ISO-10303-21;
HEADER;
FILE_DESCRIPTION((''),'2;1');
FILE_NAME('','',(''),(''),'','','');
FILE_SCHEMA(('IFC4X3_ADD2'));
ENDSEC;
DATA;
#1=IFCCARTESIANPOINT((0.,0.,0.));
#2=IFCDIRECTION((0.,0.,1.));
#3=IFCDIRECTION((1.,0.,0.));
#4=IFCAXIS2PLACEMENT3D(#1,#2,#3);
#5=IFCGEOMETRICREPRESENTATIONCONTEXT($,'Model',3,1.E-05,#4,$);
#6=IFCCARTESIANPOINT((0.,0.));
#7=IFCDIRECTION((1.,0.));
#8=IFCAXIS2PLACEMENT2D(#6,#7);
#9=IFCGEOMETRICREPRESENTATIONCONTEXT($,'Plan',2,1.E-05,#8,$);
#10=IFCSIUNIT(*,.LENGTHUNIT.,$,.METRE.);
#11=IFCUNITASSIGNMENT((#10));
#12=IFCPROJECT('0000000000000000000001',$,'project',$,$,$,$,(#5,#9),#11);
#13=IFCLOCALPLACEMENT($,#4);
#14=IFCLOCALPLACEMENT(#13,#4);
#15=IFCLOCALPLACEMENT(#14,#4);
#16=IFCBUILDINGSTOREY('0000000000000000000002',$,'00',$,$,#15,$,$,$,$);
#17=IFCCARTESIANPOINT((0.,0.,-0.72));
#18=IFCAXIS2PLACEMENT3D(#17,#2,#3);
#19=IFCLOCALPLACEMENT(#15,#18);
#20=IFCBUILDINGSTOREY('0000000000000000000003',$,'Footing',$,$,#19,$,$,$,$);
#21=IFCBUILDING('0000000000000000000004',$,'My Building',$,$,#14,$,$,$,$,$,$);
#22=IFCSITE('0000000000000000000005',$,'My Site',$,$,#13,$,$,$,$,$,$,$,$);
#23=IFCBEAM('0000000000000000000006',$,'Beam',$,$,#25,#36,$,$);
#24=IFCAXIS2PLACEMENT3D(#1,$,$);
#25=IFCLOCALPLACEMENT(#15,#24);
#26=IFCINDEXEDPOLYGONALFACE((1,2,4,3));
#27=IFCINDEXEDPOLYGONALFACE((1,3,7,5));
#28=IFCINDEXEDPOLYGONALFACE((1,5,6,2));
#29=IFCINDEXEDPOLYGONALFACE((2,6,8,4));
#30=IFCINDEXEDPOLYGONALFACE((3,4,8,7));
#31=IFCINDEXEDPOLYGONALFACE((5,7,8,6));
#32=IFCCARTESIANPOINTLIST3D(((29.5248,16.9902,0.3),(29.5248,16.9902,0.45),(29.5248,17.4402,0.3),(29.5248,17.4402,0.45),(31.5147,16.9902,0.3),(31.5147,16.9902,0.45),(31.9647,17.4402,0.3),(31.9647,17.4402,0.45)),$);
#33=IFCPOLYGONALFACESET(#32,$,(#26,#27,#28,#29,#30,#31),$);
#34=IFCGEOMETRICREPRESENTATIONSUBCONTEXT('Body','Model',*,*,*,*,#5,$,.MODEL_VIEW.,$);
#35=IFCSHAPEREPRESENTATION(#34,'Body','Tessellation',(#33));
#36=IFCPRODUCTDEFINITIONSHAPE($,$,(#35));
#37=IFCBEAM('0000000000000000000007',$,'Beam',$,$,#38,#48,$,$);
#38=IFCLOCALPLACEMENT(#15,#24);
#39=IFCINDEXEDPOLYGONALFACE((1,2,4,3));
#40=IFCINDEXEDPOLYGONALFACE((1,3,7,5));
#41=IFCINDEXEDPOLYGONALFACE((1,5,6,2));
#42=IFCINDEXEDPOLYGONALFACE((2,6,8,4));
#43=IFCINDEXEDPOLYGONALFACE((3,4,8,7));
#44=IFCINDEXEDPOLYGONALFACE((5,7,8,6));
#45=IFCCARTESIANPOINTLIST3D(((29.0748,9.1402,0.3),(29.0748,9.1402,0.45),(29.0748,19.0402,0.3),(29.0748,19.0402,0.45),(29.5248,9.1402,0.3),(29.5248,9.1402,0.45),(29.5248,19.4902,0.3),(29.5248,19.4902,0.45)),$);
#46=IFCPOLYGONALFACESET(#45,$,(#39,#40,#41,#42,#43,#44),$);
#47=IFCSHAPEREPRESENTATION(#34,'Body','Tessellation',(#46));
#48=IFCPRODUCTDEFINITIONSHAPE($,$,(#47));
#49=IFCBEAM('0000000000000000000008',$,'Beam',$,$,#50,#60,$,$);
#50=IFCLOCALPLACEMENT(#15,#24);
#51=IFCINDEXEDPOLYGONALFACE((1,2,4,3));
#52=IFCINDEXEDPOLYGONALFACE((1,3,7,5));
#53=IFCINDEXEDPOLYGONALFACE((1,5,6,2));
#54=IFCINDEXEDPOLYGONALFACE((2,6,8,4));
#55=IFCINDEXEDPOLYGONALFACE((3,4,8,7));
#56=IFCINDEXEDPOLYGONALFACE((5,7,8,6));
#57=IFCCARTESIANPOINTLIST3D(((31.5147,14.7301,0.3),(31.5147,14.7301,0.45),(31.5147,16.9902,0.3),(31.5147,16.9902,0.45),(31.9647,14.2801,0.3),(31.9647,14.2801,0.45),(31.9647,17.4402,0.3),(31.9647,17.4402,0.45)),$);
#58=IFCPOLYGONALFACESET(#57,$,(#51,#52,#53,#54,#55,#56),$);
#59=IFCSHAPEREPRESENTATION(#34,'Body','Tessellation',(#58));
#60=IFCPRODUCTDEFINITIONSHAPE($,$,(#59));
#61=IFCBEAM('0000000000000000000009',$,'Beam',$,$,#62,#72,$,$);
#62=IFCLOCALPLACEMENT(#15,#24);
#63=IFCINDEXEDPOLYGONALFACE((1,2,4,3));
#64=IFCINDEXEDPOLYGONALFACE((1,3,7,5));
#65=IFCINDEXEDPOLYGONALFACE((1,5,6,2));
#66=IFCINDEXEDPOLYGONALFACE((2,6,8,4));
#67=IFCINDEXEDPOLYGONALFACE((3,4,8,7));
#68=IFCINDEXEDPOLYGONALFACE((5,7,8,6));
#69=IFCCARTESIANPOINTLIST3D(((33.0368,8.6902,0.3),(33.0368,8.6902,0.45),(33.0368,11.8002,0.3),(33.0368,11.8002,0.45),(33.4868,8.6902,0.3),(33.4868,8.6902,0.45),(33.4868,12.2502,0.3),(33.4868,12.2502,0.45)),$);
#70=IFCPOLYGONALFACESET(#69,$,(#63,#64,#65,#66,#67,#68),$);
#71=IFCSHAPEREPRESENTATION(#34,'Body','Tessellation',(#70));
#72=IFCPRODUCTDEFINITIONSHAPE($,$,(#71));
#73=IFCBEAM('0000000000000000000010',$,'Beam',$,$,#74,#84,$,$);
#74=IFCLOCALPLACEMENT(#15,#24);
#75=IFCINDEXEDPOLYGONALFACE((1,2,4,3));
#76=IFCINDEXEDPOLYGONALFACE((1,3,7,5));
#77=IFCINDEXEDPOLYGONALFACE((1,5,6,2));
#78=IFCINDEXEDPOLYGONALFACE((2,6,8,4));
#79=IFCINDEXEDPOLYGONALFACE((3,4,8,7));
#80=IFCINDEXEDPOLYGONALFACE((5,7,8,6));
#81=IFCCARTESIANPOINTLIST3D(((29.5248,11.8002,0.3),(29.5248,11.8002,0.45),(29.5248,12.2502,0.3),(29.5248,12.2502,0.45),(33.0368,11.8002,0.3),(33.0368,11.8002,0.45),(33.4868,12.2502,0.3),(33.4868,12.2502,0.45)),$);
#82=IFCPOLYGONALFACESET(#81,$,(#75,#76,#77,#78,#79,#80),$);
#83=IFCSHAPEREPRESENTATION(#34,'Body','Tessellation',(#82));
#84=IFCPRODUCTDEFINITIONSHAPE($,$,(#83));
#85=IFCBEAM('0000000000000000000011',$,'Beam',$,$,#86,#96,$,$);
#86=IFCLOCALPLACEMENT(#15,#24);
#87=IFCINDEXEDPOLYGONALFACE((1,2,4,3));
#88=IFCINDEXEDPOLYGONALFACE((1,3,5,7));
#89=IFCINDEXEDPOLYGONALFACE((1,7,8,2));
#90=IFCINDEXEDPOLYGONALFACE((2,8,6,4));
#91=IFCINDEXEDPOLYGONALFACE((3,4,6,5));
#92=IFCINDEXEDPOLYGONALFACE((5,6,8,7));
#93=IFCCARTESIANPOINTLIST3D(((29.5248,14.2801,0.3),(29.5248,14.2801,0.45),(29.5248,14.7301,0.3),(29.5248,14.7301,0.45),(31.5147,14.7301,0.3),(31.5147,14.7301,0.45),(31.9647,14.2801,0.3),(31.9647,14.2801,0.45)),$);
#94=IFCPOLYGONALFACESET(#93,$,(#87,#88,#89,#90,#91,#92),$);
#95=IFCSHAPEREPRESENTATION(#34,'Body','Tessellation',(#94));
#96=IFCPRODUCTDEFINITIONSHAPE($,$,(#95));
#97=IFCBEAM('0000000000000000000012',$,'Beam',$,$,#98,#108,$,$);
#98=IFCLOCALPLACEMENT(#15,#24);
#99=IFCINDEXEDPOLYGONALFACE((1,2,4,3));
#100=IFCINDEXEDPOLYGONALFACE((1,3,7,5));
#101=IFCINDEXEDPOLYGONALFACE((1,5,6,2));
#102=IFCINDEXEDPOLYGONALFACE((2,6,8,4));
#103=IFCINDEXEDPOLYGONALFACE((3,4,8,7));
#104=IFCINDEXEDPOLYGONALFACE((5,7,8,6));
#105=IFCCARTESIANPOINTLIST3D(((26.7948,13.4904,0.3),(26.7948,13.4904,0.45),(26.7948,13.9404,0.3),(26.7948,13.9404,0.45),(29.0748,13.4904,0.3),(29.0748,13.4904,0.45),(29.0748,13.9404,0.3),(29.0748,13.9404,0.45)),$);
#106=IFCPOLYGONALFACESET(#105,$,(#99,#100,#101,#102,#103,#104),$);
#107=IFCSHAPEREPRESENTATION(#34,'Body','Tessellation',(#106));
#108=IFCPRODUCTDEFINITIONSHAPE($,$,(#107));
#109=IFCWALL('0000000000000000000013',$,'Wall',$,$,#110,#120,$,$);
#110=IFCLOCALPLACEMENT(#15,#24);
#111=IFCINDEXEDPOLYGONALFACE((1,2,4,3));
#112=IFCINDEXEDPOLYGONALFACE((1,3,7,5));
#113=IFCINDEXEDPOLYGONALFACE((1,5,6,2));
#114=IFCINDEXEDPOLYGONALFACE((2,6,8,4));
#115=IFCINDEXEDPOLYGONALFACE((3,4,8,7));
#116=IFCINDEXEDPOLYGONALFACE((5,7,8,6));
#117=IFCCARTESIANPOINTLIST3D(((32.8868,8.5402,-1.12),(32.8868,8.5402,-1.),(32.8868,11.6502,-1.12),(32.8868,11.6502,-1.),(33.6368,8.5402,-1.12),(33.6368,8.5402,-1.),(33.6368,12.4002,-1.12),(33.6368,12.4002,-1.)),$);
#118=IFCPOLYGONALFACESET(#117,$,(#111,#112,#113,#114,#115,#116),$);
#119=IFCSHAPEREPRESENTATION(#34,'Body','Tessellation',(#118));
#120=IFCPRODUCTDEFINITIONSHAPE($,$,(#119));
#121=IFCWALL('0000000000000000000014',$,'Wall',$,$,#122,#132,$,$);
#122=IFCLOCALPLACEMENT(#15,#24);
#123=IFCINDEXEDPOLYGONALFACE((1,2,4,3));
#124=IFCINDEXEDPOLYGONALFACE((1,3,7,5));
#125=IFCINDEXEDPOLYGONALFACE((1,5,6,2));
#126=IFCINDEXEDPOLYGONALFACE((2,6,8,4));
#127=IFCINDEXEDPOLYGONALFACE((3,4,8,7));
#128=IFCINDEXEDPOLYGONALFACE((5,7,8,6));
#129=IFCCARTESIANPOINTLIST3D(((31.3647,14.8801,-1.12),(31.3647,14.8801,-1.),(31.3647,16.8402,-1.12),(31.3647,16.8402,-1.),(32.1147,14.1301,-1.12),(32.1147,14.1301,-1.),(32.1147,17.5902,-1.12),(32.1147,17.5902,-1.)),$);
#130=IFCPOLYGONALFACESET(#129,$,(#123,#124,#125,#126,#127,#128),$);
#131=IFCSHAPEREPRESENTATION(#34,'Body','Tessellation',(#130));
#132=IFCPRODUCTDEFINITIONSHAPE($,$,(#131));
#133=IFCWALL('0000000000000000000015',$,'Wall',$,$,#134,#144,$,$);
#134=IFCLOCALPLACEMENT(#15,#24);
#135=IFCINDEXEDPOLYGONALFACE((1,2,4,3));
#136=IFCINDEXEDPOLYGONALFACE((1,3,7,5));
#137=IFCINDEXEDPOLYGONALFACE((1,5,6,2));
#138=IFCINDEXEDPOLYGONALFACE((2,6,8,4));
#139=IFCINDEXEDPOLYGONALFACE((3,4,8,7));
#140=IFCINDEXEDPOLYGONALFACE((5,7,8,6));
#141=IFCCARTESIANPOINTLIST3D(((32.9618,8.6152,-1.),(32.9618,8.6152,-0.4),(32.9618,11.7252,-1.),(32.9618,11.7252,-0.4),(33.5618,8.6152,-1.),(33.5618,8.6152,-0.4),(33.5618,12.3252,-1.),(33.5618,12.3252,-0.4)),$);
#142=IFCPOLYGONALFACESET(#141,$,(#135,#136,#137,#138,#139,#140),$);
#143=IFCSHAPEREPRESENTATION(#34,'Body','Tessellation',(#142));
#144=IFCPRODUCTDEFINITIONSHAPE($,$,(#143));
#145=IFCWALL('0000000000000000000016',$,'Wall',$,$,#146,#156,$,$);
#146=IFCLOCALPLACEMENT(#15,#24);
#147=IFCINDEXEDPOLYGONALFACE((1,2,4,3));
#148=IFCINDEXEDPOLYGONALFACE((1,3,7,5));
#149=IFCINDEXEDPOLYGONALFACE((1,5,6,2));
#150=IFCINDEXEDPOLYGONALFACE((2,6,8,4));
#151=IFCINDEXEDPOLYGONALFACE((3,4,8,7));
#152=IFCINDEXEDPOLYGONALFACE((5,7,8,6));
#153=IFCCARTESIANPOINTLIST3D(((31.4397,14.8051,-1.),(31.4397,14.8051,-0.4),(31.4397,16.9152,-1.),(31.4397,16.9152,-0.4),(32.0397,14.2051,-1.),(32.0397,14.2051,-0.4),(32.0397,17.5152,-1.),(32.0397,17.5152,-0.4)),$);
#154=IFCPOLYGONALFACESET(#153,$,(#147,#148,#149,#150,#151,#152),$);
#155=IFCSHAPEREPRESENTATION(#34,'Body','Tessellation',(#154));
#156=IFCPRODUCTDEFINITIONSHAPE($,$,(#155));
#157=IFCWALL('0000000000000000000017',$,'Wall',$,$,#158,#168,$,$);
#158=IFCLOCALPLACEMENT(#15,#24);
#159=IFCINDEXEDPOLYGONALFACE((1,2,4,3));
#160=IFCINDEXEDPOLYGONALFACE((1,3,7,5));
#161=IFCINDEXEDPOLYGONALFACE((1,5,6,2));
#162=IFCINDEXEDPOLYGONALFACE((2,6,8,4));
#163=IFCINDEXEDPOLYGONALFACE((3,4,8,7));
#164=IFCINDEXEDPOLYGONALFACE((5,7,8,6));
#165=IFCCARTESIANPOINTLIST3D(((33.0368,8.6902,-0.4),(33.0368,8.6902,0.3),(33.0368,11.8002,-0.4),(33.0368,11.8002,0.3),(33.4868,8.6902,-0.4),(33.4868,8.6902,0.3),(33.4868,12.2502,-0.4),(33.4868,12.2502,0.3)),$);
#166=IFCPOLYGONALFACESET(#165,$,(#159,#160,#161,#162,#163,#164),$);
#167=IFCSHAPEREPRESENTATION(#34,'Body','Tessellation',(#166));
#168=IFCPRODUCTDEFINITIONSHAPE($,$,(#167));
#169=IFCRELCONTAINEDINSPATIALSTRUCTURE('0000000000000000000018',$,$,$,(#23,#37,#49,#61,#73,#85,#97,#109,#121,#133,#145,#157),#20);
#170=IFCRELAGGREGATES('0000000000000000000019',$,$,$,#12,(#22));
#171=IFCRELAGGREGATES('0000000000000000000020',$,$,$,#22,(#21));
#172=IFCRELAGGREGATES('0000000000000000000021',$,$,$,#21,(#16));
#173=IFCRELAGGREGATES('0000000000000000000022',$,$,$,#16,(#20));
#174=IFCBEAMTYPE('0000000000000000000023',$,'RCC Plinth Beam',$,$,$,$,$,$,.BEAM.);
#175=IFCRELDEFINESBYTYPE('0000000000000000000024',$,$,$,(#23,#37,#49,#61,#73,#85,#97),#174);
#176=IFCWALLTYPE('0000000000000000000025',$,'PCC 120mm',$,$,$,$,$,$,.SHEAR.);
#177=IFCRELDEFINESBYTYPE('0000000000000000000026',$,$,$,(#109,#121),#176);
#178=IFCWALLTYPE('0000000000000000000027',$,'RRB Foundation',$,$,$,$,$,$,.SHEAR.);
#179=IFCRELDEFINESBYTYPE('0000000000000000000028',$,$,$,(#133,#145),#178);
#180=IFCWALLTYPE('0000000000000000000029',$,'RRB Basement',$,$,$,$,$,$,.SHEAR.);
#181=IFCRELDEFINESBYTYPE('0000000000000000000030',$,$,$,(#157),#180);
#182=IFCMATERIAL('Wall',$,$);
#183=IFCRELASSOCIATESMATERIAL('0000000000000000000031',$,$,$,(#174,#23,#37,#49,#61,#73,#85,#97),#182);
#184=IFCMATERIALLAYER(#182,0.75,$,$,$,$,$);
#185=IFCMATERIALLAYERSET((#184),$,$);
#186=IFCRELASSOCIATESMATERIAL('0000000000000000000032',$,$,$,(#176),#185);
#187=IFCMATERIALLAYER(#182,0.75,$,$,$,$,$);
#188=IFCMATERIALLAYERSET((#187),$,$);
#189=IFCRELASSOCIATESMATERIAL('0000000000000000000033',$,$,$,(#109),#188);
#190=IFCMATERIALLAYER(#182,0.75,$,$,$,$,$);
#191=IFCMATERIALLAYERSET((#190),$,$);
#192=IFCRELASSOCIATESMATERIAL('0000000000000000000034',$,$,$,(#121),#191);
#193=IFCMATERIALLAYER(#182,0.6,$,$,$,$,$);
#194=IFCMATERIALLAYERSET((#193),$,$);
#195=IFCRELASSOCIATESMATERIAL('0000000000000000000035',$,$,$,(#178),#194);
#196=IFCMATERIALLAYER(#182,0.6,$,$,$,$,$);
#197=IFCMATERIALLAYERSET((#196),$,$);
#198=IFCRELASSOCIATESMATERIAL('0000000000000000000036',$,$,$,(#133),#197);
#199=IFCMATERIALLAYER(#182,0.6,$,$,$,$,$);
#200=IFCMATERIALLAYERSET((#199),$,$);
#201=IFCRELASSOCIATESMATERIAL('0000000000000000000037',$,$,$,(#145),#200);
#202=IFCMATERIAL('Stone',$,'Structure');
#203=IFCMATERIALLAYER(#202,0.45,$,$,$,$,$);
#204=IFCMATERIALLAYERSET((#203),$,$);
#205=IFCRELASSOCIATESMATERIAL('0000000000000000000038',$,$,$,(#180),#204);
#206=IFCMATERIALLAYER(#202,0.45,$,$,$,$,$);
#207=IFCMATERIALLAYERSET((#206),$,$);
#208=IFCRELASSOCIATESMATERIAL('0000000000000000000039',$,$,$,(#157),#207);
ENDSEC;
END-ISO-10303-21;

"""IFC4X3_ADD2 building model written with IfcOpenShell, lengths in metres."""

from ifc_helpers import new_model, si_unit, frame, origin_with_axes, origin_2d_with_axis, place, context, subcontext, project, spatial, line, indexed_curve, rectangle, outline, extrude, clip, halfspace, material, layer, layer_set, layer_usage, material_profile, profile_set, profile_usage, type_object, element, save


model = new_model("IFC4X3_ADD2")

# Units and contexts
model_context = context("Model", 3, precision=1e-05, world=origin_with_axes())
plan_context = context("Plan", 2, precision=1e-05, world=origin_2d_with_axis())
body_context = subcontext(model_context, "Body", "Model", "MODEL_VIEW")
ifc_project = project(units=[si_unit("LENGTHUNIT", "METRE")], contexts=[model_context, plan_context])

# Site, building, storeys
site_placement = place(None, origin_with_axes())
site = spatial("IfcSite", under=ifc_project, at=site_placement, Name="My Site")
building_placement = place(site_placement, origin_with_axes())
building = spatial("IfcBuilding", under=site, at=building_placement, Name="My Building")
storey_1_placement = place(building_placement, origin_with_axes())
storey_1 = spatial("IfcBuildingStorey", under=building, at=storey_1_placement, Name="00")
storey_2_placement = place(storey_1_placement, frame((0.0, 0.0, -0.72), z_axis=(0.0, 0.0, 1.0), x_axis=(1.0, 0.0, 0.0)))
storey_2 = spatial("IfcBuildingStorey", under=storey_1, at=storey_2_placement, Name="Footing")

# Beams
ifc_material_1 = material(Name="Wall")
ifc_material_profile_1 = material_profile(ifc_material_1, rectangle(XDim=0.45, YDim=0.15))
ifc_profile_set_1 = profile_set([ifc_material_profile_1])
ifc_profile_usage_1 = profile_usage(ifc_profile_set_1, cardinal=5)
beam_type = type_object("IfcBeamType", Name="RCC Plinth Beam", PredefinedType="BEAM", material=ifc_profile_set_1)
beam_1_placement = place(storey_2_placement, frame((29.5248, 17.2152, 1.095), z_axis=(1.0, 0.0, 0.0), x_axis=(0.0, 1.0, 0.0)))
element("IfcBeam", 1, at=beam_1_placement, inside=storey_2, type_object=beam_type, material=ifc_profile_usage_1, Name="Beam", context=body_context, shape_type="Clipping", body=[
    clip(extrude(rectangle(XDim=0.45, YDim=0.15), origin_with_axes(), (0.0, 0.0, 1.0), 2.44), halfspace(frame((0.225, -0.375, 2.44), z_axis=(-0.707107, 0.0, 0.707107), x_axis=(0.0, 1.0, 0.0)), False)),
])
ifc_material_profile_2 = material_profile(ifc_material_1, rectangle(XDim=0.45, YDim=0.15))
ifc_profile_set_2 = profile_set([ifc_material_profile_2])
ifc_profile_usage_2 = profile_usage(ifc_profile_set_2, cardinal=5)
beam_2_placement = place(storey_2_placement, frame((29.2998, 9.1402, 1.095), z_axis=(0.0, 1.0, 0.0), x_axis=(-1.0, 0.0, 0.0)))
element("IfcBeam", 2, at=beam_2_placement, inside=storey_2, type_object=beam_type, material=ifc_profile_usage_2, Name="Beam", context=body_context, shape_type="Clipping", body=[
    clip(extrude(rectangle(XDim=0.45, YDim=0.15), origin_with_axes(), (0.0, 0.0, 1.0), 10.35), halfspace(frame((-0.225, -0.375, 10.35), z_axis=(0.707107, 0.0, 0.707107), x_axis=(0.0, -1.0, 0.0)), False)),
])
ifc_material_profile_3 = material_profile(ifc_material_1, rectangle(XDim=0.45, YDim=0.15))
ifc_profile_set_3 = profile_set([ifc_material_profile_3])
ifc_profile_usage_3 = profile_usage(ifc_profile_set_3, cardinal=5)
beam_3_placement = place(storey_2_placement, frame((31.7397, 14.2801, 1.095), z_axis=(0.0, 1.0, 0.0), x_axis=(-1.0, 0.0, 0.0)))
element("IfcBeam", 3, at=beam_3_placement, inside=storey_2, type_object=beam_type, material=ifc_profile_usage_3, Name="Beam", context=body_context, shape_type="Clipping", body=[
    clip(clip(extrude(rectangle(XDim=0.45, YDim=0.15), origin_with_axes(), (0.0, 0.0, 1.0), 3.16), halfspace(frame((-0.225, -0.375, 3.16), z_axis=(0.707107, 0.0, 0.707107), x_axis=(0.0, -1.0, 0.0)), False)), halfspace(frame((-0.225, -0.375, 0.0), z_axis=(0.707107, 0.0, -0.707107), x_axis=(0.0, -1.0, 0.0)), False)),
])
ifc_material_profile_4 = material_profile(ifc_material_1, rectangle(XDim=0.45, YDim=0.15))
ifc_profile_set_4 = profile_set([ifc_material_profile_4])
ifc_profile_usage_4 = profile_usage(ifc_profile_set_4, cardinal=5)
beam_4_placement = place(storey_2_placement, frame((33.2618, 8.6902, 1.095), z_axis=(0.0, 1.0, 0.0), x_axis=(-1.0, 0.0, 0.0)))
element("IfcBeam", 4, at=beam_4_placement, inside=storey_2, type_object=beam_type, material=ifc_profile_usage_4, Name="Beam", context=body_context, shape_type="Clipping", body=[
    clip(extrude(rectangle(XDim=0.45, YDim=0.15), origin_with_axes(), (0.0, 0.0, 1.0), 3.56), halfspace(frame((-0.225, -0.375, 3.56), z_axis=(0.70711, 0.0, 0.707104), x_axis=(0.0, -1.0, 0.0)), False)),
])
ifc_profile_usage_5 = profile_usage(ifc_profile_set_1, cardinal=5)
beam_5_placement = place(storey_2_placement, frame((29.5248, 12.0252, 1.095), z_axis=(1.0, 0.0, 0.0), x_axis=(0.0, 1.0, 0.0)))
element("IfcBeam", 5, at=beam_5_placement, inside=storey_2, type_object=beam_type, material=ifc_profile_usage_5, Name="Beam", context=body_context, shape_type="Clipping", body=[
    clip(extrude(rectangle(XDim=0.45, YDim=0.15), origin_with_axes(), (0.0, 0.0, 1.0), 3.962), halfspace(frame((0.225, -0.375, 3.962), z_axis=(-0.707104, 0.0, 0.70711), x_axis=(0.0, 1.0, 0.0)), False)),
])
ifc_profile_usage_6 = profile_usage(ifc_profile_set_1, cardinal=5)
beam_6_placement = place(storey_2_placement, frame((29.5248, 14.5051, 1.095), z_axis=(1.0, 0.0, 0.0), x_axis=(0.0, 1.0, 0.0)))
element("IfcBeam", 6, at=beam_6_placement, inside=storey_2, type_object=beam_type, material=ifc_profile_usage_6, Name="Beam", context=body_context, shape_type="Clipping", body=[
    clip(extrude(rectangle(XDim=0.45, YDim=0.15), origin_with_axes(), (0.0, 0.0, 1.0), 2.44), halfspace(frame((-0.225, -0.375, 2.44), z_axis=(0.707107, 0.0, 0.707107), x_axis=(0.0, -1.0, 0.0)), False)),
])
ifc_profile_usage_7 = profile_usage(ifc_profile_set_1, cardinal=5)
beam_7_placement = place(storey_2_placement, frame((26.7948, 13.7154, 1.095), z_axis=(1.0, 0.0, 0.0), x_axis=(0.0, 1.0, 0.0)))
element("IfcBeam", 7, at=beam_7_placement, inside=storey_2, type_object=beam_type, material=ifc_profile_usage_7, Name="Beam", context=body_context, shape_type="SweptSolid", body=[
    extrude(rectangle(XDim=0.45, YDim=0.15), origin_with_axes(), (0.0, 0.0, 1.0), 2.28),
])

# Walls
ifc_layer_1 = layer(ifc_material_1, 0.75)
ifc_layer_set_1 = layer_set([ifc_layer_1])
wall_type_1 = type_object("IfcWallType", Name="PCC 120mm", PredefinedType="SHEAR", material=ifc_layer_set_1)
ifc_layer_2 = layer(ifc_material_1, 0.75)
ifc_layer_set_2 = layer_set([ifc_layer_2])
ifc_layer_usage_1 = layer_usage(ifc_layer_set_2, "AXIS2", "NEGATIVE", 0.0)
wall_1_placement = place(storey_2_placement, frame((32.8868, 8.5402, -0.4), z_axis=(0.0, 0.0, 1.0), x_axis=(0.0, 1.0, 0.0)))
element("IfcWall", 8, at=wall_1_placement, inside=storey_2, type_object=wall_type_1, material=ifc_layer_usage_1, Name="Wall", context=body_context, shape_type="SweptSolid", body=[
    extrude(outline(indexed_curve([(0.0, -0.75), (0.0, 0.0), (3.11, 0.0), (3.86, -0.75)], segments=[line(1, 2, 3, 4, 1)])), origin_with_axes(), (0.0, 0.0, 1.0), 0.12),
])
ifc_layer_3 = layer(ifc_material_1, 0.75)
ifc_layer_set_3 = layer_set([ifc_layer_3])
ifc_layer_usage_2 = layer_usage(ifc_layer_set_3, "AXIS2", "NEGATIVE", 0.0)
wall_2_placement = place(storey_2_placement, frame((31.3647, 14.1301, -0.4), z_axis=(0.0, 0.0, 1.0), x_axis=(0.0, 1.0, 0.0)))
element("IfcWall", 9, at=wall_2_placement, inside=storey_2, type_object=wall_type_1, material=ifc_layer_usage_2, Name="Wall", context=body_context, shape_type="SweptSolid", body=[
    extrude(outline(indexed_curve([(0.0, -0.75), (0.75, 0.0), (2.71, 0.0), (3.46, -0.75)], segments=[line(1, 2, 3, 4, 1)])), origin_with_axes(), (0.0, 0.0, 1.0), 0.12),
])
ifc_layer_4 = layer(ifc_material_1, 0.6)
ifc_layer_set_4 = layer_set([ifc_layer_4])
wall_type_2 = type_object("IfcWallType", Name="RRB Foundation", PredefinedType="SHEAR", material=ifc_layer_set_4)
ifc_layer_5 = layer(ifc_material_1, 0.6)
ifc_layer_set_5 = layer_set([ifc_layer_5])
ifc_layer_usage_3 = layer_usage(ifc_layer_set_5, "AXIS2", "NEGATIVE", 0.0)
wall_3_placement = place(storey_2_placement, frame((32.9618, 8.6152, -0.28), z_axis=(0.0, 0.0, 1.0), x_axis=(0.0, 1.0, 0.0)))
element("IfcWall", 10, at=wall_3_placement, inside=storey_2, type_object=wall_type_2, material=ifc_layer_usage_3, Name="Wall", context=body_context, shape_type="SweptSolid", body=[
    extrude(outline(indexed_curve([(0.0, -0.6), (0.0, 0.0), (3.11, 0.0), (3.71, -0.6)], segments=[line(1, 2, 3, 4, 1)])), origin_with_axes(), (0.0, 0.0, 1.0), 0.6),
])
ifc_layer_6 = layer(ifc_material_1, 0.6)
ifc_layer_set_6 = layer_set([ifc_layer_6])
ifc_layer_usage_4 = layer_usage(ifc_layer_set_6, "AXIS2", "NEGATIVE", 0.0)
wall_4_placement = place(storey_2_placement, frame((31.4397, 14.2051, -0.28), z_axis=(0.0, 0.0, 1.0), x_axis=(0.0, 1.0, 0.0)))
element("IfcWall", 11, at=wall_4_placement, inside=storey_2, type_object=wall_type_2, material=ifc_layer_usage_4, Name="Wall", context=body_context, shape_type="SweptSolid", body=[
    extrude(outline(indexed_curve([(0.0, -0.6), (0.6, 0.0), (2.71, 0.0), (3.31, -0.6)], segments=[line(1, 2, 3, 4, 1)])), origin_with_axes(), (0.0, 0.0, 1.0), 0.6),
])
ifc_material_2 = material(Name="Stone", Category="Structure")
ifc_layer_7 = layer(ifc_material_2, 0.45)
ifc_layer_set_7 = layer_set([ifc_layer_7])
wall_type_3 = type_object("IfcWallType", Name="RRB Basement", PredefinedType="SHEAR", material=ifc_layer_set_7)
ifc_layer_8 = layer(ifc_material_2, 0.45)
ifc_layer_set_8 = layer_set([ifc_layer_8])
ifc_layer_usage_5 = layer_usage(ifc_layer_set_8, "AXIS2", "NEGATIVE", 0.0)
wall_5_placement = place(storey_2_placement, frame((33.0368, 8.6902, 0.32), z_axis=(0.0, 0.0, 1.0), x_axis=(0.0, 1.0, 0.0)))
element("IfcWall", 12, at=wall_5_placement, inside=storey_2, type_object=wall_type_3, material=ifc_layer_usage_5, Name="Wall", context=body_context, shape_type="SweptSolid", body=[
    extrude(outline(indexed_curve([(0.0, -0.45), (0.0, 0.0), (3.11, 0.0), (3.56, -0.45)], segments=[line(1, 2, 3, 4, 1)])), origin_with_axes(), (0.0, 0.0, 1.0), 0.7),
])

save(model, "model.ifc")
